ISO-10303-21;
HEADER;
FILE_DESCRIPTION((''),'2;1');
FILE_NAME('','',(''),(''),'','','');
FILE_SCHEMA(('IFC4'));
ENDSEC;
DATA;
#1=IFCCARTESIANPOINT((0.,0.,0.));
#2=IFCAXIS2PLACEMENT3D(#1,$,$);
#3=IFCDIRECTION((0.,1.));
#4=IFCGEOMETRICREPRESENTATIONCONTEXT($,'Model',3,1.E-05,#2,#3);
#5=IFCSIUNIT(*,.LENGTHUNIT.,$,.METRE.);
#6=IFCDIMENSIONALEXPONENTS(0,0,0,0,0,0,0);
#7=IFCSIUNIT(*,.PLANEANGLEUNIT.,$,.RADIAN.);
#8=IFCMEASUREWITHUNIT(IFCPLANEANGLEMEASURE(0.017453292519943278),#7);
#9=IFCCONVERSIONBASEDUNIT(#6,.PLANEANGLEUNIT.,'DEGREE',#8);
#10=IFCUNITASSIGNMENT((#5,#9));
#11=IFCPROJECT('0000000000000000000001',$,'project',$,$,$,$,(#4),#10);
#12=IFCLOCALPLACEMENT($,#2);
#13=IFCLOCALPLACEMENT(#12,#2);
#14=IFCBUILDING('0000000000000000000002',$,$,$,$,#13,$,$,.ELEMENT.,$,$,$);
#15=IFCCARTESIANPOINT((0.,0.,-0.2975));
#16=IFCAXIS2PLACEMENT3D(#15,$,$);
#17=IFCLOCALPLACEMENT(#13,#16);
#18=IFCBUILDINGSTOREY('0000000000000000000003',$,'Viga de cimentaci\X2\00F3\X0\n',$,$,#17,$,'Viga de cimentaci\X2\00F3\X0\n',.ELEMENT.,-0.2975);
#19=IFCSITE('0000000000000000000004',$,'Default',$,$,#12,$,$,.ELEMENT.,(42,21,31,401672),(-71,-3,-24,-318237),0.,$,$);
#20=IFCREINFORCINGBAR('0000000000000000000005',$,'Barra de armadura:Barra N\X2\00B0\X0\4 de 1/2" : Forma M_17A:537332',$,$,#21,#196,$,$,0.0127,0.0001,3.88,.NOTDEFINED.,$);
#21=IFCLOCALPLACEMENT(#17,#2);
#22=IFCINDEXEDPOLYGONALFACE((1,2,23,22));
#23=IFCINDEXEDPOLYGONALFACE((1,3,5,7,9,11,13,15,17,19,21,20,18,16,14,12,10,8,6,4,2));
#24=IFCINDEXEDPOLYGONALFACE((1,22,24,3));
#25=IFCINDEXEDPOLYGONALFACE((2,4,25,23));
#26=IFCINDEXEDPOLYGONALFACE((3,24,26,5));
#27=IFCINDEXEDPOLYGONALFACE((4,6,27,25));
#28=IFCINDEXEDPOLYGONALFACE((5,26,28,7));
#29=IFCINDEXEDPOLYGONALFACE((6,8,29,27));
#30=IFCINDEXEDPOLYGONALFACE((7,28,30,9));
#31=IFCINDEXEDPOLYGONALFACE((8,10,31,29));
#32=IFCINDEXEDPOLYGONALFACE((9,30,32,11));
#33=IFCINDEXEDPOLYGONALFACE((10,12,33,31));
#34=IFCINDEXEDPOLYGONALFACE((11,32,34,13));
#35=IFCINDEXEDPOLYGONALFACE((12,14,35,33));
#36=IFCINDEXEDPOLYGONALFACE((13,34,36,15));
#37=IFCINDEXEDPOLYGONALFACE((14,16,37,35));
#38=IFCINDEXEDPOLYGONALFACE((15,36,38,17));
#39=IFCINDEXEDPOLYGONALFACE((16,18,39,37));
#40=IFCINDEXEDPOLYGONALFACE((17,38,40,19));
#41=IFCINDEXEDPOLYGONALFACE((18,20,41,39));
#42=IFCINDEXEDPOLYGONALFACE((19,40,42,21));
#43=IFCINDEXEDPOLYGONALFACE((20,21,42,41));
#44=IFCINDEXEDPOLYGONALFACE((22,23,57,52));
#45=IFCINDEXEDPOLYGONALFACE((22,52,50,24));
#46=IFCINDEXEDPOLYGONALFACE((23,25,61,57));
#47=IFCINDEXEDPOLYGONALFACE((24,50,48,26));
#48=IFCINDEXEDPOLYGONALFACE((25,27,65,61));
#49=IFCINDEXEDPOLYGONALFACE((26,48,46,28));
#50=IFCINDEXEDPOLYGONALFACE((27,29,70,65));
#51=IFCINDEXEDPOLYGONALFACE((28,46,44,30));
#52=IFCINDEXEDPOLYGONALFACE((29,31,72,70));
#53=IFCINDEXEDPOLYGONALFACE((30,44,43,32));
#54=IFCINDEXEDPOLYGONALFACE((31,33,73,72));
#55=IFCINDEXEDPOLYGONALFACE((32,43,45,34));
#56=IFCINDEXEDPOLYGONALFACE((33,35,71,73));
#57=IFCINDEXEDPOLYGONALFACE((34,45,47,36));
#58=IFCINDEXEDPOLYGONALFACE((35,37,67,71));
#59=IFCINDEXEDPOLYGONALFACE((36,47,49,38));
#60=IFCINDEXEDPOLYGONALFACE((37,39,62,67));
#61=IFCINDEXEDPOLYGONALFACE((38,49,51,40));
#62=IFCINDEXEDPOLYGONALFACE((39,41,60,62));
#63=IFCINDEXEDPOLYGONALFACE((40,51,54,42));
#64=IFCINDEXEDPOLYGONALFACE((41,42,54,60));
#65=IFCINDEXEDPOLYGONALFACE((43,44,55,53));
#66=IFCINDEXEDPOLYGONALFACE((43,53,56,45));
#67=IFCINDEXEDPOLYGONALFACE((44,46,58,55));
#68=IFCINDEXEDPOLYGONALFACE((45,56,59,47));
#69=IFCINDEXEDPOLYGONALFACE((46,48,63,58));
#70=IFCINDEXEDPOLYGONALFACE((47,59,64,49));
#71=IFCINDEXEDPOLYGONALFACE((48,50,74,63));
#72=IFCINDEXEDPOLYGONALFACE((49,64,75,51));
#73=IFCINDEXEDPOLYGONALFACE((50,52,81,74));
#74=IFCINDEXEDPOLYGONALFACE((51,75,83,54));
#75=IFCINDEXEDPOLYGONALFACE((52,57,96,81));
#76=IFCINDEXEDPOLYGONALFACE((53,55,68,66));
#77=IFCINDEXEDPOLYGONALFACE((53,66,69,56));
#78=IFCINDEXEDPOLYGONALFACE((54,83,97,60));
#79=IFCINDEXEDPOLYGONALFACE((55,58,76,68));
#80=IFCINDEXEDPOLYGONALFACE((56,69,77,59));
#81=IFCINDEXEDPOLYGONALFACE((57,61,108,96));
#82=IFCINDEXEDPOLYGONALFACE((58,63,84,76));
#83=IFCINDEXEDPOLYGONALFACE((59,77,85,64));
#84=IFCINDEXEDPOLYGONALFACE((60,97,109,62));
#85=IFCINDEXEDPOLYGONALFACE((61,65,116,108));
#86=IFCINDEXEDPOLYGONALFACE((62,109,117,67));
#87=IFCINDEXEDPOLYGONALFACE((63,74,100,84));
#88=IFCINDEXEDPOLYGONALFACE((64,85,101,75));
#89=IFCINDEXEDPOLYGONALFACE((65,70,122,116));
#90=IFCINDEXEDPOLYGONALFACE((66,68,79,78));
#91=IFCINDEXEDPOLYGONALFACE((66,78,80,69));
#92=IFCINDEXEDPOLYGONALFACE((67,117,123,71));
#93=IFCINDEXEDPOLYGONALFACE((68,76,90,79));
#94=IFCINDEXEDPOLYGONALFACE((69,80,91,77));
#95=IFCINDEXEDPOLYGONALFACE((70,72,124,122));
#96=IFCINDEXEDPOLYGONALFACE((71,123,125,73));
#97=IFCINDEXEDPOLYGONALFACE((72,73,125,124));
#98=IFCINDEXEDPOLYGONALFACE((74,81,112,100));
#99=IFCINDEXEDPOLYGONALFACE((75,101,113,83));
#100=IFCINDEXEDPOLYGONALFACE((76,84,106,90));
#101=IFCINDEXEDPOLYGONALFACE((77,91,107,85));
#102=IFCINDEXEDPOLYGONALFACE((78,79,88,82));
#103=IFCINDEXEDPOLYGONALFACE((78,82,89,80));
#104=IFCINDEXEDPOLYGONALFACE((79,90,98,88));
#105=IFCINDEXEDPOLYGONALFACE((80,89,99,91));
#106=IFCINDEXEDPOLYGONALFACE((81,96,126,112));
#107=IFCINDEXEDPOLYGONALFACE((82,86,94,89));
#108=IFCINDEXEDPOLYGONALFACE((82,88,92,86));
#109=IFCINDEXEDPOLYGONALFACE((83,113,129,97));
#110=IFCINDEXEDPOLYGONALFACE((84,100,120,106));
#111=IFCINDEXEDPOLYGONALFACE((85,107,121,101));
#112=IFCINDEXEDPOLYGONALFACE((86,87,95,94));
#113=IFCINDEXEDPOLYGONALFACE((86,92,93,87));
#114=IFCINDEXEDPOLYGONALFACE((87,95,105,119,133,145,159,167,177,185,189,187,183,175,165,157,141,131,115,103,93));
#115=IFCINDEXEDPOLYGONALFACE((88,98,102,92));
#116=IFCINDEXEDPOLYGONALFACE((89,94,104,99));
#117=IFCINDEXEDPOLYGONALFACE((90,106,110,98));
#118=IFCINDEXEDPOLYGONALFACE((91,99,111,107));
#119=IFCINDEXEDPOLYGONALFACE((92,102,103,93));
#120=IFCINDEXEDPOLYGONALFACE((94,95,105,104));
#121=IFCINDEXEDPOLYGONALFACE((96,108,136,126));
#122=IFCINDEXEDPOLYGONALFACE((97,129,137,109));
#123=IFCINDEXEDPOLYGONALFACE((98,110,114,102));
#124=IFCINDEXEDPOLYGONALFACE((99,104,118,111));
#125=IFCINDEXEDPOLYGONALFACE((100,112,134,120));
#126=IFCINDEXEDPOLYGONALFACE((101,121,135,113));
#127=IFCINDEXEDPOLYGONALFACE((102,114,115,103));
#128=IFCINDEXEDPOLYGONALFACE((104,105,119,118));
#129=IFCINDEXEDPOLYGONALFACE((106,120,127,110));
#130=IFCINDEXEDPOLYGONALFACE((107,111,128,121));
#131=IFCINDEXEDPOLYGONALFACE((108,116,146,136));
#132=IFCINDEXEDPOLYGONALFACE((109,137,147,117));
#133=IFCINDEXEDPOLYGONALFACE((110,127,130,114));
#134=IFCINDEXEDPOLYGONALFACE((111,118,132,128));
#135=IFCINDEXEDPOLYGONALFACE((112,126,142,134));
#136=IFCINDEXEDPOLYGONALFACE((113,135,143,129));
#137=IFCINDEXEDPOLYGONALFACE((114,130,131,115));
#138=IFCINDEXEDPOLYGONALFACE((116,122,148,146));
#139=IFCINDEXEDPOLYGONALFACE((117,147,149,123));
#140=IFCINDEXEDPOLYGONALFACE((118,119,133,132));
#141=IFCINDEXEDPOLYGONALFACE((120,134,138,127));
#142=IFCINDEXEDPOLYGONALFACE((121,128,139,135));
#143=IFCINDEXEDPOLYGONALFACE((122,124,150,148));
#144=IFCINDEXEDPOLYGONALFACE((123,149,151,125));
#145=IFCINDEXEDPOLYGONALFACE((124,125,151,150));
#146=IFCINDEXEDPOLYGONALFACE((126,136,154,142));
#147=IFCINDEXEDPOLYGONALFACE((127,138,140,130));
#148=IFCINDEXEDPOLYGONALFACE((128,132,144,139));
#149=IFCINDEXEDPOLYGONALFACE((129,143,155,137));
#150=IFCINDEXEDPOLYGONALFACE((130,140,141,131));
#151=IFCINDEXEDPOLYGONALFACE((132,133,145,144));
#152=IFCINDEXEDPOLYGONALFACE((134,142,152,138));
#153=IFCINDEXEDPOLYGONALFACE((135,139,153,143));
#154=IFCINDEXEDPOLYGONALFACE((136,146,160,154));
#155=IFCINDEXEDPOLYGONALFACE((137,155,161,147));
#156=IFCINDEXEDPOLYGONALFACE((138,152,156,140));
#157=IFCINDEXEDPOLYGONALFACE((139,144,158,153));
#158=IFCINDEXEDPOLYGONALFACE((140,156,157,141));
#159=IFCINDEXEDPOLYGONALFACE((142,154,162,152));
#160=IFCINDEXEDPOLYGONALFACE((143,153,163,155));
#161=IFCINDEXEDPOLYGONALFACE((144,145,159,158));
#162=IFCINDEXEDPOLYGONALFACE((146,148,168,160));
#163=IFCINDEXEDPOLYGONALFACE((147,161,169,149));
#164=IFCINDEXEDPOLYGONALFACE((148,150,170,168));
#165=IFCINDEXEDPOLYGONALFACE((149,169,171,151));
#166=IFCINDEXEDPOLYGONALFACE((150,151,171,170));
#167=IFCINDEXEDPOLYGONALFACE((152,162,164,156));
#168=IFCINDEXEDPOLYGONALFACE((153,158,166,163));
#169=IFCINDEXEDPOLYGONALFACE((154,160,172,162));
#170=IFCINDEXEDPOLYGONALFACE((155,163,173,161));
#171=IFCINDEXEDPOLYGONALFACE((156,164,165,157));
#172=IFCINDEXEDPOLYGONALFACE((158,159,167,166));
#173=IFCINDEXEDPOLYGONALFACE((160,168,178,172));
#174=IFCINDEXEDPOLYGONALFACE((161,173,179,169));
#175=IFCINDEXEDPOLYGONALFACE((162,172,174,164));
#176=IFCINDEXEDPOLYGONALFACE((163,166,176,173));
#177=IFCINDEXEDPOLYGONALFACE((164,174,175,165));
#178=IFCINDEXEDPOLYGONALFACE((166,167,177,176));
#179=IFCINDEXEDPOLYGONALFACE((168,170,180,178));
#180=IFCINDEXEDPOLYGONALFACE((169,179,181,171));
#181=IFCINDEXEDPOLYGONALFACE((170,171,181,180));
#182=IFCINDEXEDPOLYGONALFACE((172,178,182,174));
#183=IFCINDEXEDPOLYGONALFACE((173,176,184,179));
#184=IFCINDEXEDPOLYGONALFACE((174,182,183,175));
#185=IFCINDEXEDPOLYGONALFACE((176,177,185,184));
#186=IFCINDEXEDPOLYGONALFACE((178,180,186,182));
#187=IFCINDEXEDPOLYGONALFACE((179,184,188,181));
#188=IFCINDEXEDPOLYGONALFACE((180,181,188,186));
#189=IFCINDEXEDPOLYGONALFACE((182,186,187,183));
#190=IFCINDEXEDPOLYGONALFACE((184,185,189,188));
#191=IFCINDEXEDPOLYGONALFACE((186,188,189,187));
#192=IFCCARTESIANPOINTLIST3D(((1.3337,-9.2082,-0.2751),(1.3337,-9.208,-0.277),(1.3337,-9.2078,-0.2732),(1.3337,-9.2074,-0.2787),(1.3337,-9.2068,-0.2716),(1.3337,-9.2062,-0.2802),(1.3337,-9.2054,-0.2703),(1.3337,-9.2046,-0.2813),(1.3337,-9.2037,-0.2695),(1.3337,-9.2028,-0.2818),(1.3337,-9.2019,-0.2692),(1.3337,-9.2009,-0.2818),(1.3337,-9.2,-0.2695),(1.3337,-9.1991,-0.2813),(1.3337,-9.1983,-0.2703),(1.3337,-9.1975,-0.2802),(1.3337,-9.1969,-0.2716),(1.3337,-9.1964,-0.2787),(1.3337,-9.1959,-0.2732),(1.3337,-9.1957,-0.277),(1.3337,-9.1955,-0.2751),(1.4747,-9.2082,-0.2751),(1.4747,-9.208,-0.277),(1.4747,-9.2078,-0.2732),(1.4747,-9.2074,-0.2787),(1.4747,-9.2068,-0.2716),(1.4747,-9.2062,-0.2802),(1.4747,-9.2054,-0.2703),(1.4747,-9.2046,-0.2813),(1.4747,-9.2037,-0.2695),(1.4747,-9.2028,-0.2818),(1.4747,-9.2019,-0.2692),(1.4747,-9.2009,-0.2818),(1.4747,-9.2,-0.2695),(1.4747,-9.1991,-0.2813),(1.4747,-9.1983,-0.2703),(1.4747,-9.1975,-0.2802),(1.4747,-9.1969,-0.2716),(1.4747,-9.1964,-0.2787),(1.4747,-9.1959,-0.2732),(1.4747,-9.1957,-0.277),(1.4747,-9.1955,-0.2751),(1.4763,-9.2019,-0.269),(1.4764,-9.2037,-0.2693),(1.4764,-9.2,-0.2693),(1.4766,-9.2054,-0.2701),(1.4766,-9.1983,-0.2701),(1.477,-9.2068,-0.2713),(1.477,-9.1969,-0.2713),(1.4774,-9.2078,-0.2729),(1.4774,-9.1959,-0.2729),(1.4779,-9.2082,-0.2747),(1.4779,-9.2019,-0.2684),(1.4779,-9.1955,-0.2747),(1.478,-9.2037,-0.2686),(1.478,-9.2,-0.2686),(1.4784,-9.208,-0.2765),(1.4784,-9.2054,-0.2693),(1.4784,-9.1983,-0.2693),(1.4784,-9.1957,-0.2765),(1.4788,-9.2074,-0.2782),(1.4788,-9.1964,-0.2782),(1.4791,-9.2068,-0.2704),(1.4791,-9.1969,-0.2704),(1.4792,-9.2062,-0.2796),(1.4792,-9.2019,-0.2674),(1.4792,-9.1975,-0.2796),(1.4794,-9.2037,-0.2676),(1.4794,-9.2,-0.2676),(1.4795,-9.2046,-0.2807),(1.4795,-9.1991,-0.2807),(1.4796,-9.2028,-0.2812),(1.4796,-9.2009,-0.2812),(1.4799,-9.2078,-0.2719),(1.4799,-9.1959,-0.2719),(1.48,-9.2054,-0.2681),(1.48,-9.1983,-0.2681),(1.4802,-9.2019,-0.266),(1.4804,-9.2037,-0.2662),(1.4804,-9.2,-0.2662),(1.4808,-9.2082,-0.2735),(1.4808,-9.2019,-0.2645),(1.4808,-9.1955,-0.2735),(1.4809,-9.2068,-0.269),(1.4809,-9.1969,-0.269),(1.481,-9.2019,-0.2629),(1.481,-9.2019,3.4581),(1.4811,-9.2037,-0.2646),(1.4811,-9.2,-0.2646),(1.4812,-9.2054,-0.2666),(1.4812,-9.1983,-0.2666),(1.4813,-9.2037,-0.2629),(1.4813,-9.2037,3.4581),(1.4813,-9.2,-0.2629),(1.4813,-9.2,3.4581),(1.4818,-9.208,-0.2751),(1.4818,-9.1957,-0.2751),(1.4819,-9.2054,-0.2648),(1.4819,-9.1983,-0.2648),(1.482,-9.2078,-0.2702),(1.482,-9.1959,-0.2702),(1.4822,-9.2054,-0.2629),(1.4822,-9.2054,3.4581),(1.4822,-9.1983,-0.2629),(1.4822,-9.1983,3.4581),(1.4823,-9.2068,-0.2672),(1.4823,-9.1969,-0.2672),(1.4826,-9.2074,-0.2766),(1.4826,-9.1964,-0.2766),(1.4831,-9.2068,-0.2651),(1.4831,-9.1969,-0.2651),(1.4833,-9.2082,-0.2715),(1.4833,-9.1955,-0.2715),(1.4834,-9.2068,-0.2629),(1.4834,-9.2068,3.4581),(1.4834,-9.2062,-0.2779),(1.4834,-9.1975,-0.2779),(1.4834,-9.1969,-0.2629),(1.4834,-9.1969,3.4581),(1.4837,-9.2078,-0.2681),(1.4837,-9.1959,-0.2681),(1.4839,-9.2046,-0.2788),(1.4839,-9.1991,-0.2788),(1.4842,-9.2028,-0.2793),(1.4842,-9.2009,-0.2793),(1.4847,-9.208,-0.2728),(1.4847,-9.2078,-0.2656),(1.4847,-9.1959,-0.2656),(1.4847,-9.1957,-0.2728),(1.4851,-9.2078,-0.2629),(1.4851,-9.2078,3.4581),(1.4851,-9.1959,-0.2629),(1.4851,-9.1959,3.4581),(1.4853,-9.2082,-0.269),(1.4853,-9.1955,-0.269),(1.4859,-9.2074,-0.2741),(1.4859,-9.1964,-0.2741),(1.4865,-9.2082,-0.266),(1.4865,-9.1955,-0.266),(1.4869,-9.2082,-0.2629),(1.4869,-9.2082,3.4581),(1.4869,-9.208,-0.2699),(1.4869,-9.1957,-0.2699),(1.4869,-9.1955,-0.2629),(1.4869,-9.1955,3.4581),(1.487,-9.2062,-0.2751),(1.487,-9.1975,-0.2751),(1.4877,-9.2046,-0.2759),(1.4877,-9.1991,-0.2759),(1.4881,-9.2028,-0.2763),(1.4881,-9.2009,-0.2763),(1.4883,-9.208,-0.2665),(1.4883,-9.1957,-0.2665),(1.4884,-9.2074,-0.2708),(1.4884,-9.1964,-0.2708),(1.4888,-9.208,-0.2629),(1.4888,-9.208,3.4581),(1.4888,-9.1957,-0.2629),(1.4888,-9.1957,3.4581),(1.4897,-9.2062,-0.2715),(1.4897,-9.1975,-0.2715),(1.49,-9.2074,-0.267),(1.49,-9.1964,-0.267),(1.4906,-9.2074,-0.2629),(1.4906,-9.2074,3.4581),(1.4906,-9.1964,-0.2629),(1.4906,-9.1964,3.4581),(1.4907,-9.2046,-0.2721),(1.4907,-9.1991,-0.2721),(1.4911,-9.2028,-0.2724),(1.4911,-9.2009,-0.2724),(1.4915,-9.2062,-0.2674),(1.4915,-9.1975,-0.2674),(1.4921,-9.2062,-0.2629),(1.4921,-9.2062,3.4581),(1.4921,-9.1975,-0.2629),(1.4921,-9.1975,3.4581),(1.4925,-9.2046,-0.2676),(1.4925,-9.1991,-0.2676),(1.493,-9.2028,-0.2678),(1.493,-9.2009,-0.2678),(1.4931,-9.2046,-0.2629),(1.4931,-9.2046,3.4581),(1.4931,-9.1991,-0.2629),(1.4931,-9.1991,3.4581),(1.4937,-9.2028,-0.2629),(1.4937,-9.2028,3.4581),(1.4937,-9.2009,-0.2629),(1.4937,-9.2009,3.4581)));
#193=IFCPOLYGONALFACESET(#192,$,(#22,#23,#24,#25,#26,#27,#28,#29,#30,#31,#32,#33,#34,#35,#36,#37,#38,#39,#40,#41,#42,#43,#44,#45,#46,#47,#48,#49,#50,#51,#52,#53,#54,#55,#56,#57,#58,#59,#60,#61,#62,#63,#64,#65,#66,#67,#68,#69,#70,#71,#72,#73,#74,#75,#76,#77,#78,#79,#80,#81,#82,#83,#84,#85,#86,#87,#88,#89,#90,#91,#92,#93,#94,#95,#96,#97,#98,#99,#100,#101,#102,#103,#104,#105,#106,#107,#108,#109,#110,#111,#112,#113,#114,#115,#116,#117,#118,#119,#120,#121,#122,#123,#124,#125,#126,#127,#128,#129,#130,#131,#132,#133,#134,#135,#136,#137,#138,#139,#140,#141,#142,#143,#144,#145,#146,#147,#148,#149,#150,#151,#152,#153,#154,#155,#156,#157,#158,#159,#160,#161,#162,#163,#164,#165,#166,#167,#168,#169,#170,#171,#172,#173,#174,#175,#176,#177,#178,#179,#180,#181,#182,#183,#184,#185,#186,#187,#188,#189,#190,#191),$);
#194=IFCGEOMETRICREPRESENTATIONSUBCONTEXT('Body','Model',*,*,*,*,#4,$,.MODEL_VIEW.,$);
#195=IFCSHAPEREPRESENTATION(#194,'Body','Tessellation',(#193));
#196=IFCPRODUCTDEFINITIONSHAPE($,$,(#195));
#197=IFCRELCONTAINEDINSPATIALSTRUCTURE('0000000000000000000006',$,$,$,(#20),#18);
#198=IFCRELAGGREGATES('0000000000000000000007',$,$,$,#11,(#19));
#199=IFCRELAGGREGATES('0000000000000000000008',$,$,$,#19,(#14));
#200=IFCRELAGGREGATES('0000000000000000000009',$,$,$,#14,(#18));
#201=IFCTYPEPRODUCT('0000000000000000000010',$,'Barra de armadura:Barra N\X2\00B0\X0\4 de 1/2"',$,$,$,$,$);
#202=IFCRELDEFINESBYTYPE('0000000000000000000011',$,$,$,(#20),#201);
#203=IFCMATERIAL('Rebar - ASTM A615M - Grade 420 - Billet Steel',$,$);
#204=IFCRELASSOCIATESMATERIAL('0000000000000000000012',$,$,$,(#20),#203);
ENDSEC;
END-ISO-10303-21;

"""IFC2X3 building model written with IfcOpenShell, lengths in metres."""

from ifc_helpers import new_model, entity, si_unit, converted_unit, direction, frame, origin, place, context, subcontext, project, spatial, material, type_object, element, save


model = new_model("IFC2X3")

# Units and contexts
model_context = context("Model", 3, precision=1e-05, world=origin(), true_north=direction((0.0, 1.0)))
body_context = subcontext(model_context, "Body", "Model", "MODEL_VIEW")
ifc_project = project(units=[si_unit("LENGTHUNIT", "METRE"), converted_unit("PLANEANGLEUNIT", "DEGREE", entity("IfcPlaneAngleMeasure", 0.017453292519943278), si_unit("PLANEANGLEUNIT", "RADIAN"), dimensions=[0, 0, 0, 0, 0, 0, 0])], contexts=[model_context])

# Site, building, storey
site_placement = place(None, origin())
site = spatial("IfcSite", under=ifc_project, at=site_placement, Name="Default", CompositionType="ELEMENT", RefLatitude=(42, 21, 31, 401672), RefLongitude=(-71, -3, -24, -318237), RefElevation=0.0)
building_placement = place(site_placement, origin())
building = spatial("IfcBuilding", under=site, at=building_placement, CompositionType="ELEMENT")
storey_placement = place(building_placement, frame((0.0, 0.0, -0.2975)))
storey = spatial("IfcBuildingStorey", under=building, at=storey_placement, Name="Viga de cimentación", LongName="Viga de cimentación", CompositionType="ELEMENT", Elevation=-0.2975)

# Reinforcing bar
ifc_material = material(Name="Rebar - ASTM A615M - Grade 420 - Billet Steel")
type_product_1 = type_object("IfcTypeProduct", Name="Barra de armadura:Barra N°4 de 1/2\"")
reinforcing_bar_1_placement = place(storey_placement, origin())
element("IfcReinforcingBar", 1, at=reinforcing_bar_1_placement, inside=storey, type_object=type_product_1, material=ifc_material, Name="Barra de armadura:Barra N°4 de 1/2\" : Forma M_17A:537332", BarLength=3.88, BarRole="NOTDEFINED", CrossSectionArea=0.0001, NominalDiameter=0.0127, context=body_context, shape_type="AdvancedSweptSolid", body=[
    entity("IfcSweptDiskSolid", entity("IfcCompositeCurve", [entity("IfcCompositeCurveSegment", "CONTINUOUS", True, entity("IfcPolyline", [entity("IfcCartesianPoint", [1.4874, -9.2019, 3.4581]), entity("IfcCartesianPoint", [1.4874, -9.2019, -0.2629])])), entity("IfcCompositeCurveSegment", "CONTINUOUS", True, entity("IfcTrimmedCurve", entity("IfcCircle", entity("IfcAxis2Placement3D", entity("IfcCartesianPoint", [1.4747, -9.2019, -0.2629]), entity("IfcDirection", [0.0, 1.0, 0.0]), entity("IfcDirection", [0.0, 0.0, -1.0])), 0.0127), [entity("IfcParameterValue", 270.0)], [entity("IfcParameterValue", 360.0)], True, "PARAMETER")), entity("IfcCompositeCurveSegment", "CONTINUOUS", True, entity("IfcPolyline", [entity("IfcCartesianPoint", [1.4747, -9.2019, -0.2756]), entity("IfcCartesianPoint", [1.3337, -9.2019, -0.2756])]))], False), 0.0063, None, 0.0, 92.0),
])

save(model, "model.ifc")
